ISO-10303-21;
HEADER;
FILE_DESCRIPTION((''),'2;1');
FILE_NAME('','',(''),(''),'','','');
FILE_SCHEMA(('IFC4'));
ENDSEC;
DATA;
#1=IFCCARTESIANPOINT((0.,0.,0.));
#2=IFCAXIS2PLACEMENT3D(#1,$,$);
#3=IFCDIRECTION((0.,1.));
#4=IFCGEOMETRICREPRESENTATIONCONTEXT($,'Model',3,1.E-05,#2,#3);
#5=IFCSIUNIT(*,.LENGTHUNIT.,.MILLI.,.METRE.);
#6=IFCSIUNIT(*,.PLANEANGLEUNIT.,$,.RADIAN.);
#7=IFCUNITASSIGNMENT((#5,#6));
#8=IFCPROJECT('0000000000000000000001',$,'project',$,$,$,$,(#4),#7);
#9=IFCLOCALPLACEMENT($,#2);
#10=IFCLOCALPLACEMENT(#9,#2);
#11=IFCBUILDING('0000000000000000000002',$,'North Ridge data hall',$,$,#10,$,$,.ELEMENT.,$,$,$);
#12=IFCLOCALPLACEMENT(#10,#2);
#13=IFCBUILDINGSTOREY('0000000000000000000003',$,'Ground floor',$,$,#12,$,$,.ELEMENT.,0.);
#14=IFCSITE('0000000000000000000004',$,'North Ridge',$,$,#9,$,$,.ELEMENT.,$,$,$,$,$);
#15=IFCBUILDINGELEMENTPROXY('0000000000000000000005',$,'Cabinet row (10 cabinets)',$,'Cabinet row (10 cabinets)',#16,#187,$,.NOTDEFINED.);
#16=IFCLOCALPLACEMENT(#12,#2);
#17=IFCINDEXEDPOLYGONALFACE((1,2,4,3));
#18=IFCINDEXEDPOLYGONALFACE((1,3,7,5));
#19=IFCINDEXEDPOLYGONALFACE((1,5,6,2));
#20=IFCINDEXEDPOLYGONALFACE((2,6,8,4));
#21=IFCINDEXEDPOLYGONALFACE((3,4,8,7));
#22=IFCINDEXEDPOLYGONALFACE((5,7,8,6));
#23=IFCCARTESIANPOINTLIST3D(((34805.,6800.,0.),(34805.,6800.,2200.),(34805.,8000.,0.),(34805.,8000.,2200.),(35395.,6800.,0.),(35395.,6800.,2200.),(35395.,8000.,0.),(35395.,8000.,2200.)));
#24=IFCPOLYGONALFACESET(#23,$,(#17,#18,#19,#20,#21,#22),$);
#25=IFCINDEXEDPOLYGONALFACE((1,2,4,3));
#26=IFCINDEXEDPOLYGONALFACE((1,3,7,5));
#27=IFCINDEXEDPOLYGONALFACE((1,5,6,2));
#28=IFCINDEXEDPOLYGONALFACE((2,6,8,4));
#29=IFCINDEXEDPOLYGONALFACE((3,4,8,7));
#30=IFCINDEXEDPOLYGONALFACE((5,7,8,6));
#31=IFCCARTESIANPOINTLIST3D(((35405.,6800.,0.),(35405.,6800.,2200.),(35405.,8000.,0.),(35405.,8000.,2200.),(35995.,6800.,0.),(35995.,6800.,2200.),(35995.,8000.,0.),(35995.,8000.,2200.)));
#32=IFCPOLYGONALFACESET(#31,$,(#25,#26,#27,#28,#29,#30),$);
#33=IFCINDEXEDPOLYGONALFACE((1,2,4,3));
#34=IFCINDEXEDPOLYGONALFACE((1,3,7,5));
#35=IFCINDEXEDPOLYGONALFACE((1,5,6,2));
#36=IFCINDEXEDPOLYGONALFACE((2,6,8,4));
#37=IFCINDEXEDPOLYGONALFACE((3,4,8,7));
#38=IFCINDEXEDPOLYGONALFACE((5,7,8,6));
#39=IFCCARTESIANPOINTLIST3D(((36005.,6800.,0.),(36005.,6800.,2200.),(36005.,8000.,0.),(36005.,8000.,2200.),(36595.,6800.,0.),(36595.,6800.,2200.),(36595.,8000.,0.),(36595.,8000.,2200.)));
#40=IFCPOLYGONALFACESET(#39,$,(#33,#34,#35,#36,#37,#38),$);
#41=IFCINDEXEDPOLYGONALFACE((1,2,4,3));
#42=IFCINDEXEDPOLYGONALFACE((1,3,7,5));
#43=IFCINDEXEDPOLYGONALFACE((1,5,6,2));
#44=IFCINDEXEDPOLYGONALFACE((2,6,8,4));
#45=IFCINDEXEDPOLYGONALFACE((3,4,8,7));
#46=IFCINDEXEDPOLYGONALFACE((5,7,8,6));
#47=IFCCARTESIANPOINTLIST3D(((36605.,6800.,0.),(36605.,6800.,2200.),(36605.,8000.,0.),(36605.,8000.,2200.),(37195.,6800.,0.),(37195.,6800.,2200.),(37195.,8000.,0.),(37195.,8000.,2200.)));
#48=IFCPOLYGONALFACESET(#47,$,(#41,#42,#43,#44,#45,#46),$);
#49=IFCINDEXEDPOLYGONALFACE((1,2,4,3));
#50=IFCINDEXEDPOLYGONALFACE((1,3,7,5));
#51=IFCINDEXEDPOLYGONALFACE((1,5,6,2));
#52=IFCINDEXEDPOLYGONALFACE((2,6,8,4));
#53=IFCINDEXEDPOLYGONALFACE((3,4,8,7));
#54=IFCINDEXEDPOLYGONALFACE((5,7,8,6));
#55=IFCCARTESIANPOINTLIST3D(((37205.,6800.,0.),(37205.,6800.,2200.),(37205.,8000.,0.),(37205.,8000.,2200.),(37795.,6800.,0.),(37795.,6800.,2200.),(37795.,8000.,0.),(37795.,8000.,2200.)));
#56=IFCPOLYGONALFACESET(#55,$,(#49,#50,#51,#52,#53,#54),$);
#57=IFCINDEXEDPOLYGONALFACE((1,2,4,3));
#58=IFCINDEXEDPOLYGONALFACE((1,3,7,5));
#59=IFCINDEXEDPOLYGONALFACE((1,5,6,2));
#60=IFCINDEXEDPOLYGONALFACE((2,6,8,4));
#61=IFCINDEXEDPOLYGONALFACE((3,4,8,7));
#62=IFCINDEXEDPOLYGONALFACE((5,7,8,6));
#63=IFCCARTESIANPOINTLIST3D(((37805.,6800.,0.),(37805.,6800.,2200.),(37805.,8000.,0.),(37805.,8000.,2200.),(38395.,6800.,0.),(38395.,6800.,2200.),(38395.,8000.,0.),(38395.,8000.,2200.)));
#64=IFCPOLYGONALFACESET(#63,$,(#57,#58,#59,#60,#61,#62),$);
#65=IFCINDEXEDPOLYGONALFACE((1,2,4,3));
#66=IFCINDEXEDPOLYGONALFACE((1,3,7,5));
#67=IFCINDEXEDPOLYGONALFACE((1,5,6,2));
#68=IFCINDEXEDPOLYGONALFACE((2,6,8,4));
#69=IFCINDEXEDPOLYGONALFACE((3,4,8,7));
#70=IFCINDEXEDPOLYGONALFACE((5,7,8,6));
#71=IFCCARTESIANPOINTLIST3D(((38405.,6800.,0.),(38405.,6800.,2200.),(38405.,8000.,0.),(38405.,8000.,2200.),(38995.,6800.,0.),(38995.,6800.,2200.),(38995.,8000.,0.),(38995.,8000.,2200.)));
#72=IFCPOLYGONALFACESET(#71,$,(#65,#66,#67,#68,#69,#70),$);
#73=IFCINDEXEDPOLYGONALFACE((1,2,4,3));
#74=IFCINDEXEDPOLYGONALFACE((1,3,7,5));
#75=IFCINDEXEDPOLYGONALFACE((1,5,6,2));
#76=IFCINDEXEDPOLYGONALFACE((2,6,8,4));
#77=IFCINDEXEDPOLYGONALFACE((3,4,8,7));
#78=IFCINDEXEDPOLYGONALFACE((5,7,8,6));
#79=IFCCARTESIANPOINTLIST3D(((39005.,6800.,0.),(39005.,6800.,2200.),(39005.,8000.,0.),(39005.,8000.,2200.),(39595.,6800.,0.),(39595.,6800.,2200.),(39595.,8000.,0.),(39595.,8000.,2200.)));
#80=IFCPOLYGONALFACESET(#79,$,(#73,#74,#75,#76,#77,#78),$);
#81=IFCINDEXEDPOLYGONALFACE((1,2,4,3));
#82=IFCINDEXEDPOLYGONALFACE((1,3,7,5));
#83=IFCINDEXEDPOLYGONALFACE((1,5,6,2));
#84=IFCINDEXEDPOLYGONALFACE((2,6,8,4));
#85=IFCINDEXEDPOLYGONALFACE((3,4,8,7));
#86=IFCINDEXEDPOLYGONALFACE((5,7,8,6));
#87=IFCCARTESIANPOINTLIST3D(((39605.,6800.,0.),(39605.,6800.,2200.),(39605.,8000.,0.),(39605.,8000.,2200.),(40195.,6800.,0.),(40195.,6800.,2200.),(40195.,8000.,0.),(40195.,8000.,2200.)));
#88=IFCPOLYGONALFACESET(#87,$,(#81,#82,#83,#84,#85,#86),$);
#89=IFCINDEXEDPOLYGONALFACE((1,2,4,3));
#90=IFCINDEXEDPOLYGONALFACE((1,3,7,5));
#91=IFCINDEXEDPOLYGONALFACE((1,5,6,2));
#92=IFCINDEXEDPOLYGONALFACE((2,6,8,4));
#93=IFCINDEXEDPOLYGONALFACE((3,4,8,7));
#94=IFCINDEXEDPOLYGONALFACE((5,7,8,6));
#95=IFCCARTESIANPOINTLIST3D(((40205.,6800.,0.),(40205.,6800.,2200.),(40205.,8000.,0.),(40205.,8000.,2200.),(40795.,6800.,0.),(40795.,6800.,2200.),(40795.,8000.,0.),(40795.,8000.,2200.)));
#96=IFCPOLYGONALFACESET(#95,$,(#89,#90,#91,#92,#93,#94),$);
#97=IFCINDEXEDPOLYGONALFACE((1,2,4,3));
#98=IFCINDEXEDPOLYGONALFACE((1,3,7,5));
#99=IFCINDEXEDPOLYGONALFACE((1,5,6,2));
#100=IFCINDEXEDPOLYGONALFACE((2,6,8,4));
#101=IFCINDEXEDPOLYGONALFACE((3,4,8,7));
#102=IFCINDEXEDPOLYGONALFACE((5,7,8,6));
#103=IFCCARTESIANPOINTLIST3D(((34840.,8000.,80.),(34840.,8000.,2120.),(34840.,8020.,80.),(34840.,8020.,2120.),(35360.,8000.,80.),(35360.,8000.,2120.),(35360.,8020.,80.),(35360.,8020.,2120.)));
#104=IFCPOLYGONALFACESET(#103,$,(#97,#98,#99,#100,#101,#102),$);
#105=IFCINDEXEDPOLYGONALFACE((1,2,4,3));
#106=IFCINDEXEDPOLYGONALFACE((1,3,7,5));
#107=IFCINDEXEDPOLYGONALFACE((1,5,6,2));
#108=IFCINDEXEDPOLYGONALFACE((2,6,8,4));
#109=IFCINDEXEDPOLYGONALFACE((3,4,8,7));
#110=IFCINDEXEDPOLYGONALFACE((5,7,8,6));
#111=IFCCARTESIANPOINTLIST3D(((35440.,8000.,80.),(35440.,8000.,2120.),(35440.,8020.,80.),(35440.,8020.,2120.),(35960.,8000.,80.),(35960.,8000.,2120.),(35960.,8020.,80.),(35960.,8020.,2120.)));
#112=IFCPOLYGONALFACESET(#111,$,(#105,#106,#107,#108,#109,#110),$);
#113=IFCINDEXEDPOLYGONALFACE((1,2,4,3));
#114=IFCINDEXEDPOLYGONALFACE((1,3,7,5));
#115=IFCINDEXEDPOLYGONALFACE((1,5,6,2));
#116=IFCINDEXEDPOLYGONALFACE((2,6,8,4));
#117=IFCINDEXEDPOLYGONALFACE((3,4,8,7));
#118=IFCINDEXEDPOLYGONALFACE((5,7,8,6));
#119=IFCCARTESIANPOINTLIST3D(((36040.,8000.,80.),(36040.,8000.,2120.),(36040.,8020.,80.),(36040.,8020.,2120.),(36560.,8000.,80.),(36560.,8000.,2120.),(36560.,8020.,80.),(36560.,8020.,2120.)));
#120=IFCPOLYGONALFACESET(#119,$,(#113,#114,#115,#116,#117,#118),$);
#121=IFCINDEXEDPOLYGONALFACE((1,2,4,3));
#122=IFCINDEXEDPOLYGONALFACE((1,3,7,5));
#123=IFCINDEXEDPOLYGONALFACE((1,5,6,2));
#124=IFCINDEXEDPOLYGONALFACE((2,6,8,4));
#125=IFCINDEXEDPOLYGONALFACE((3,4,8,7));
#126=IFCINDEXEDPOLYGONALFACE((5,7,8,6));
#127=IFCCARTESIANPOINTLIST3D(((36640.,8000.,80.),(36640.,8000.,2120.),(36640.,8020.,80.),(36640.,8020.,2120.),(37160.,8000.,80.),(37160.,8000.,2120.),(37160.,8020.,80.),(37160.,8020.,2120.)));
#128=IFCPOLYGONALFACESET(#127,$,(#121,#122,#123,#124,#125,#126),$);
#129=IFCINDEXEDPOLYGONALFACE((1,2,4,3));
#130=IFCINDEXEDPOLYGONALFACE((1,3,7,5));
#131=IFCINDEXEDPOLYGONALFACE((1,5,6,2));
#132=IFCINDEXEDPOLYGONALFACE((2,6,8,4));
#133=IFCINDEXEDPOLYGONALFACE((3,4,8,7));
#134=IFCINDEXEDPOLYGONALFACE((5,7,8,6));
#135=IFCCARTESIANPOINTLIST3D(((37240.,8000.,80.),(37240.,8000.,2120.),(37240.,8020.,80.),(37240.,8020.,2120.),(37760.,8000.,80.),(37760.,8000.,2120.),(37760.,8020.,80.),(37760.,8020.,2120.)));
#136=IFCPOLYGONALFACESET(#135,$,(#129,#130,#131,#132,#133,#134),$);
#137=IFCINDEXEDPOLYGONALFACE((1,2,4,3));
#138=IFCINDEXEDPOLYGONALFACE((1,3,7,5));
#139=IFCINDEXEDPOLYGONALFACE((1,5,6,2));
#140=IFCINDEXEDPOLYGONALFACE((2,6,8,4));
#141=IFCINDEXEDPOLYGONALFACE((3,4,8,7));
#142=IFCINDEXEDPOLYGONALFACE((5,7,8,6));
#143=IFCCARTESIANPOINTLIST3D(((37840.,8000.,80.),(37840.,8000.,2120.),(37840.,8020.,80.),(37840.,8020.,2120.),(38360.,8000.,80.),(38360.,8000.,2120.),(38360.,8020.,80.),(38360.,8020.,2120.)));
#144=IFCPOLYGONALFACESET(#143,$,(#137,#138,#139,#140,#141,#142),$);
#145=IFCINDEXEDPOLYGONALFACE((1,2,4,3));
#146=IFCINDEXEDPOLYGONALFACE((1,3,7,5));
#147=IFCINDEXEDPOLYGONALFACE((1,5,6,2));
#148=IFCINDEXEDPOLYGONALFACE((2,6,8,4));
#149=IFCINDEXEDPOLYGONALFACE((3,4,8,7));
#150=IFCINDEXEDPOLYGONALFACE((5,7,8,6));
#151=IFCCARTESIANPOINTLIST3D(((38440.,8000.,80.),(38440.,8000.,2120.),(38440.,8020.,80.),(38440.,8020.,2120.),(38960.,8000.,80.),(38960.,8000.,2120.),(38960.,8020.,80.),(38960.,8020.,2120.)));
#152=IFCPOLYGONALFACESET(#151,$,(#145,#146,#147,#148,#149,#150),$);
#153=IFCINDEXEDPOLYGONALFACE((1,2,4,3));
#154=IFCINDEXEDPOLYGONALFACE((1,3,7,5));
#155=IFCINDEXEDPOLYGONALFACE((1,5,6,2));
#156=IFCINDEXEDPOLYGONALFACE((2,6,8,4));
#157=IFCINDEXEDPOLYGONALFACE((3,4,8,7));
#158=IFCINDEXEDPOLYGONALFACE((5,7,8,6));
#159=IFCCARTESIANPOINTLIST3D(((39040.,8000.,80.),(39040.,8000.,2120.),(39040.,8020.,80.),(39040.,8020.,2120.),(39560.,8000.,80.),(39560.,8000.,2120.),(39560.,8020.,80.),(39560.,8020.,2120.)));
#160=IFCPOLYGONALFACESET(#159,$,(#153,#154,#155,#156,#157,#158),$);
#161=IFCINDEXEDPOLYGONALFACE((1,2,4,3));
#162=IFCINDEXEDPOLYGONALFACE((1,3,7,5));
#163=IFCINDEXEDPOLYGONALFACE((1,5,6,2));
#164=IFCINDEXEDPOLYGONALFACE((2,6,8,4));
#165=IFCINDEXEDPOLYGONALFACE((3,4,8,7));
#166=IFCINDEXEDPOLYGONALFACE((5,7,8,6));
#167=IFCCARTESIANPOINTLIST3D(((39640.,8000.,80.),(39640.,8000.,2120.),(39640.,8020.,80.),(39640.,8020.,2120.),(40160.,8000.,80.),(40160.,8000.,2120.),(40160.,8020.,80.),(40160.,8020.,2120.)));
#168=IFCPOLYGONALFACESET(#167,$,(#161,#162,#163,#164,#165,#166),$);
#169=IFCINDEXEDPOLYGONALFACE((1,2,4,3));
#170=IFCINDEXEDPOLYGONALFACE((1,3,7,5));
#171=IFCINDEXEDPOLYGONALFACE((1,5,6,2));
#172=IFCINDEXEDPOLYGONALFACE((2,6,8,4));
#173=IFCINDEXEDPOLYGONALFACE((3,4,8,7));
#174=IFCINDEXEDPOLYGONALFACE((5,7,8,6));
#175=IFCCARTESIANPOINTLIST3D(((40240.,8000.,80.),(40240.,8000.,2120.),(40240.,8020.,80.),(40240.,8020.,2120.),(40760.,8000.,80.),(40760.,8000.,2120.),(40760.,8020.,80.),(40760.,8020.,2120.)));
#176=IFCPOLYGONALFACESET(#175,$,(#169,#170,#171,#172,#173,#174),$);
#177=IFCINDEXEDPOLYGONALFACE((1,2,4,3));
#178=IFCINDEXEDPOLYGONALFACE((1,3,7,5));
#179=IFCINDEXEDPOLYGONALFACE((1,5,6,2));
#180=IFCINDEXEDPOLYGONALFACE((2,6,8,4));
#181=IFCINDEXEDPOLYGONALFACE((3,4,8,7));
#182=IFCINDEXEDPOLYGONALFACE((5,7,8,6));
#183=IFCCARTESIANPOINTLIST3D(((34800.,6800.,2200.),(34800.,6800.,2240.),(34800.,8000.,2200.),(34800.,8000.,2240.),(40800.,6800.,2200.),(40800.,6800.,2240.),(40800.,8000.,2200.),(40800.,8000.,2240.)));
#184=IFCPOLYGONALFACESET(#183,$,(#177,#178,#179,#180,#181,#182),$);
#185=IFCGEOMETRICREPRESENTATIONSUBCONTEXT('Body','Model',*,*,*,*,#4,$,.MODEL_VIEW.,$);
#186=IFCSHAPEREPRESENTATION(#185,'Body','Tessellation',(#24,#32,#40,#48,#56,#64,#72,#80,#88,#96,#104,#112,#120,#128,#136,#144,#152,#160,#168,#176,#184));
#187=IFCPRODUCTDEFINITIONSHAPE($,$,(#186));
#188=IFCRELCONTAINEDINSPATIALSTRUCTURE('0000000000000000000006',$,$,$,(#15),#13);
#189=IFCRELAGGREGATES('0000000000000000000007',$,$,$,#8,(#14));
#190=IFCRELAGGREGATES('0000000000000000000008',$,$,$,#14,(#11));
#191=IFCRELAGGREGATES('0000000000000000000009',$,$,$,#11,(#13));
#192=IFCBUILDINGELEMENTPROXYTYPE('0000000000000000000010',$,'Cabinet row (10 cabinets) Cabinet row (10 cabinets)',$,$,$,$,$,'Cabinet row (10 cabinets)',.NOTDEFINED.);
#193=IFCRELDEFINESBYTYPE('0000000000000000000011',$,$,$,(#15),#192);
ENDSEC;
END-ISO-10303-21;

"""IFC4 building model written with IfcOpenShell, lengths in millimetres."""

from ifc_helpers import new_model, si_unit, direction, frame, origin, place, context, subcontext, project, spatial, polyline, outline, extrude, source, transform, mapped, type_object, type_shapes, element, save


model = new_model("IFC4")

# Units and contexts
model_context = context("Model", 3, precision=1e-05, world=origin(), true_north=direction((0.0, 1.0)))
body_context = subcontext(model_context, "Body", "Model", "MODEL_VIEW")
ifc_project = project(units=[si_unit("LENGTHUNIT", "METRE", prefix="MILLI"), si_unit("PLANEANGLEUNIT", "RADIAN")], contexts=[model_context])

# Site, building, storey
site_placement = place(None, origin())
site = spatial("IfcSite", under=ifc_project, at=site_placement, Name="North Ridge", CompositionType="ELEMENT")
building_placement = place(site_placement, origin())
building = spatial("IfcBuilding", under=site, at=building_placement, Name="North Ridge data hall", CompositionType="ELEMENT")
storey_placement = place(building_placement, origin())
storey = spatial("IfcBuildingStorey", under=building, at=storey_placement, Name="Ground floor", CompositionType="ELEMENT", Elevation=0.0)

# Building element proxy
building_element_proxy_type_1 = type_object("IfcBuildingElementProxyType", Name="Cabinet row (10 cabinets) Cabinet row (10 cabinets)", ElementType="Cabinet row (10 cabinets)", PredefinedType="NOTDEFINED")
shared_shape_1 = source(origin(), body_context, "Body", "SweptSolid", [
    extrude(outline(polyline([(5.0, 0.0), (595.0, 0.0), (595.0, 1200.0), (5.0, 1200.0), (5.0, 0.0)])), origin(), (0.0, 0.0, 1.0), 2200.0),
    extrude(outline(polyline([(605.0, 0.0), (1195.0, 0.0), (1195.0, 1200.0), (605.0, 1200.0), (605.0, 0.0)])), origin(), (0.0, 0.0, 1.0), 2200.0),
    extrude(outline(polyline([(1205.0, 0.0), (1795.0, 0.0), (1795.0, 1200.0), (1205.0, 1200.0), (1205.0, 0.0)])), origin(), (0.0, 0.0, 1.0), 2200.0),
    extrude(outline(polyline([(1805.0, 0.0), (2395.0, 0.0), (2395.0, 1200.0), (1805.0, 1200.0), (1805.0, 0.0)])), origin(), (0.0, 0.0, 1.0), 2200.0),
    extrude(outline(polyline([(2405.0, 0.0), (2995.0, 0.0), (2995.0, 1200.0), (2405.0, 1200.0), (2405.0, 0.0)])), origin(), (0.0, 0.0, 1.0), 2200.0),
    extrude(outline(polyline([(3005.0, 0.0), (3595.0, 0.0), (3595.0, 1200.0), (3005.0, 1200.0), (3005.0, 0.0)])), origin(), (0.0, 0.0, 1.0), 2200.0),
    extrude(outline(polyline([(3605.0, 0.0), (4195.0, 0.0), (4195.0, 1200.0), (3605.0, 1200.0), (3605.0, 0.0)])), origin(), (0.0, 0.0, 1.0), 2200.0),
    extrude(outline(polyline([(4205.0, 0.0), (4795.0, 0.0), (4795.0, 1200.0), (4205.0, 1200.0), (4205.0, 0.0)])), origin(), (0.0, 0.0, 1.0), 2200.0),
    extrude(outline(polyline([(4805.0, 0.0), (5395.0, 0.0), (5395.0, 1200.0), (4805.0, 1200.0), (4805.0, 0.0)])), origin(), (0.0, 0.0, 1.0), 2200.0),
    extrude(outline(polyline([(5405.0, 0.0), (5995.0, 0.0), (5995.0, 1200.0), (5405.0, 1200.0), (5405.0, 0.0)])), origin(), (0.0, 0.0, 1.0), 2200.0),
    extrude(outline(polyline([(40.0, 1200.0), (560.0, 1200.0), (560.0, 1220.0), (40.0, 1220.0), (40.0, 1200.0)])), frame((0.0, 0.0, 80.0)), (0.0, 0.0, 1.0), 2040.0),
    extrude(outline(polyline([(640.0, 1200.0), (1160.0, 1200.0), (1160.0, 1220.0), (640.0, 1220.0), (640.0, 1200.0)])), frame((0.0, 0.0, 80.0)), (0.0, 0.0, 1.0), 2040.0),
    extrude(outline(polyline([(1240.0, 1200.0), (1760.0, 1200.0), (1760.0, 1220.0), (1240.0, 1220.0), (1240.0, 1200.0)])), frame((0.0, 0.0, 80.0)), (0.0, 0.0, 1.0), 2040.0),
    extrude(outline(polyline([(1840.0, 1200.0), (2360.0, 1200.0), (2360.0, 1220.0), (1840.0, 1220.0), (1840.0, 1200.0)])), frame((0.0, 0.0, 80.0)), (0.0, 0.0, 1.0), 2040.0),
    extrude(outline(polyline([(2440.0, 1200.0), (2960.0, 1200.0), (2960.0, 1220.0), (2440.0, 1220.0), (2440.0, 1200.0)])), frame((0.0, 0.0, 80.0)), (0.0, 0.0, 1.0), 2040.0),
    extrude(outline(polyline([(3040.0, 1200.0), (3560.0, 1200.0), (3560.0, 1220.0), (3040.0, 1220.0), (3040.0, 1200.0)])), frame((0.0, 0.0, 80.0)), (0.0, 0.0, 1.0), 2040.0),
    extrude(outline(polyline([(3640.0, 1200.0), (4160.0, 1200.0), (4160.0, 1220.0), (3640.0, 1220.0), (3640.0, 1200.0)])), frame((0.0, 0.0, 80.0)), (0.0, 0.0, 1.0), 2040.0),
    extrude(outline(polyline([(4240.0, 1200.0), (4760.0, 1200.0), (4760.0, 1220.0), (4240.0, 1220.0), (4240.0, 1200.0)])), frame((0.0, 0.0, 80.0)), (0.0, 0.0, 1.0), 2040.0),
    extrude(outline(polyline([(4840.0, 1200.0), (5360.0, 1200.0), (5360.0, 1220.0), (4840.0, 1220.0), (4840.0, 1200.0)])), frame((0.0, 0.0, 80.0)), (0.0, 0.0, 1.0), 2040.0),
    extrude(outline(polyline([(5440.0, 1200.0), (5960.0, 1200.0), (5960.0, 1220.0), (5440.0, 1220.0), (5440.0, 1200.0)])), frame((0.0, 0.0, 80.0)), (0.0, 0.0, 1.0), 2040.0),
    extrude(outline(polyline([(0.0, 0.0), (6000.0, 0.0), (6000.0, 1200.0), (0.0, 1200.0), (0.0, 0.0)])), frame((0.0, 0.0, 2200.0)), (0.0, 0.0, 1.0), 40.0),
])
type_shapes(building_element_proxy_type_1, [shared_shape_1])
for number, where, z_axis, x_axis, name in (
    (1, (34800.0, 6800.0, 0.0), (0.0, 0.0, 1.0), (1.0, 0.0, 0.0), "Cabinet row (10 cabinets)"),
):
    element("IfcBuildingElementProxy", number, at=place(storey_placement, frame(where, z_axis=z_axis, x_axis=x_axis)), inside=storey, type_object=building_element_proxy_type_1, Name=name, ObjectType="Cabinet row (10 cabinets)", PredefinedType="NOTDEFINED", context=body_context, shape_type="MappedRepresentation", body=[
        mapped(shared_shape_1, transform((0.0, 0.0, 0.0))),
    ])

save(model, "model.ifc")
